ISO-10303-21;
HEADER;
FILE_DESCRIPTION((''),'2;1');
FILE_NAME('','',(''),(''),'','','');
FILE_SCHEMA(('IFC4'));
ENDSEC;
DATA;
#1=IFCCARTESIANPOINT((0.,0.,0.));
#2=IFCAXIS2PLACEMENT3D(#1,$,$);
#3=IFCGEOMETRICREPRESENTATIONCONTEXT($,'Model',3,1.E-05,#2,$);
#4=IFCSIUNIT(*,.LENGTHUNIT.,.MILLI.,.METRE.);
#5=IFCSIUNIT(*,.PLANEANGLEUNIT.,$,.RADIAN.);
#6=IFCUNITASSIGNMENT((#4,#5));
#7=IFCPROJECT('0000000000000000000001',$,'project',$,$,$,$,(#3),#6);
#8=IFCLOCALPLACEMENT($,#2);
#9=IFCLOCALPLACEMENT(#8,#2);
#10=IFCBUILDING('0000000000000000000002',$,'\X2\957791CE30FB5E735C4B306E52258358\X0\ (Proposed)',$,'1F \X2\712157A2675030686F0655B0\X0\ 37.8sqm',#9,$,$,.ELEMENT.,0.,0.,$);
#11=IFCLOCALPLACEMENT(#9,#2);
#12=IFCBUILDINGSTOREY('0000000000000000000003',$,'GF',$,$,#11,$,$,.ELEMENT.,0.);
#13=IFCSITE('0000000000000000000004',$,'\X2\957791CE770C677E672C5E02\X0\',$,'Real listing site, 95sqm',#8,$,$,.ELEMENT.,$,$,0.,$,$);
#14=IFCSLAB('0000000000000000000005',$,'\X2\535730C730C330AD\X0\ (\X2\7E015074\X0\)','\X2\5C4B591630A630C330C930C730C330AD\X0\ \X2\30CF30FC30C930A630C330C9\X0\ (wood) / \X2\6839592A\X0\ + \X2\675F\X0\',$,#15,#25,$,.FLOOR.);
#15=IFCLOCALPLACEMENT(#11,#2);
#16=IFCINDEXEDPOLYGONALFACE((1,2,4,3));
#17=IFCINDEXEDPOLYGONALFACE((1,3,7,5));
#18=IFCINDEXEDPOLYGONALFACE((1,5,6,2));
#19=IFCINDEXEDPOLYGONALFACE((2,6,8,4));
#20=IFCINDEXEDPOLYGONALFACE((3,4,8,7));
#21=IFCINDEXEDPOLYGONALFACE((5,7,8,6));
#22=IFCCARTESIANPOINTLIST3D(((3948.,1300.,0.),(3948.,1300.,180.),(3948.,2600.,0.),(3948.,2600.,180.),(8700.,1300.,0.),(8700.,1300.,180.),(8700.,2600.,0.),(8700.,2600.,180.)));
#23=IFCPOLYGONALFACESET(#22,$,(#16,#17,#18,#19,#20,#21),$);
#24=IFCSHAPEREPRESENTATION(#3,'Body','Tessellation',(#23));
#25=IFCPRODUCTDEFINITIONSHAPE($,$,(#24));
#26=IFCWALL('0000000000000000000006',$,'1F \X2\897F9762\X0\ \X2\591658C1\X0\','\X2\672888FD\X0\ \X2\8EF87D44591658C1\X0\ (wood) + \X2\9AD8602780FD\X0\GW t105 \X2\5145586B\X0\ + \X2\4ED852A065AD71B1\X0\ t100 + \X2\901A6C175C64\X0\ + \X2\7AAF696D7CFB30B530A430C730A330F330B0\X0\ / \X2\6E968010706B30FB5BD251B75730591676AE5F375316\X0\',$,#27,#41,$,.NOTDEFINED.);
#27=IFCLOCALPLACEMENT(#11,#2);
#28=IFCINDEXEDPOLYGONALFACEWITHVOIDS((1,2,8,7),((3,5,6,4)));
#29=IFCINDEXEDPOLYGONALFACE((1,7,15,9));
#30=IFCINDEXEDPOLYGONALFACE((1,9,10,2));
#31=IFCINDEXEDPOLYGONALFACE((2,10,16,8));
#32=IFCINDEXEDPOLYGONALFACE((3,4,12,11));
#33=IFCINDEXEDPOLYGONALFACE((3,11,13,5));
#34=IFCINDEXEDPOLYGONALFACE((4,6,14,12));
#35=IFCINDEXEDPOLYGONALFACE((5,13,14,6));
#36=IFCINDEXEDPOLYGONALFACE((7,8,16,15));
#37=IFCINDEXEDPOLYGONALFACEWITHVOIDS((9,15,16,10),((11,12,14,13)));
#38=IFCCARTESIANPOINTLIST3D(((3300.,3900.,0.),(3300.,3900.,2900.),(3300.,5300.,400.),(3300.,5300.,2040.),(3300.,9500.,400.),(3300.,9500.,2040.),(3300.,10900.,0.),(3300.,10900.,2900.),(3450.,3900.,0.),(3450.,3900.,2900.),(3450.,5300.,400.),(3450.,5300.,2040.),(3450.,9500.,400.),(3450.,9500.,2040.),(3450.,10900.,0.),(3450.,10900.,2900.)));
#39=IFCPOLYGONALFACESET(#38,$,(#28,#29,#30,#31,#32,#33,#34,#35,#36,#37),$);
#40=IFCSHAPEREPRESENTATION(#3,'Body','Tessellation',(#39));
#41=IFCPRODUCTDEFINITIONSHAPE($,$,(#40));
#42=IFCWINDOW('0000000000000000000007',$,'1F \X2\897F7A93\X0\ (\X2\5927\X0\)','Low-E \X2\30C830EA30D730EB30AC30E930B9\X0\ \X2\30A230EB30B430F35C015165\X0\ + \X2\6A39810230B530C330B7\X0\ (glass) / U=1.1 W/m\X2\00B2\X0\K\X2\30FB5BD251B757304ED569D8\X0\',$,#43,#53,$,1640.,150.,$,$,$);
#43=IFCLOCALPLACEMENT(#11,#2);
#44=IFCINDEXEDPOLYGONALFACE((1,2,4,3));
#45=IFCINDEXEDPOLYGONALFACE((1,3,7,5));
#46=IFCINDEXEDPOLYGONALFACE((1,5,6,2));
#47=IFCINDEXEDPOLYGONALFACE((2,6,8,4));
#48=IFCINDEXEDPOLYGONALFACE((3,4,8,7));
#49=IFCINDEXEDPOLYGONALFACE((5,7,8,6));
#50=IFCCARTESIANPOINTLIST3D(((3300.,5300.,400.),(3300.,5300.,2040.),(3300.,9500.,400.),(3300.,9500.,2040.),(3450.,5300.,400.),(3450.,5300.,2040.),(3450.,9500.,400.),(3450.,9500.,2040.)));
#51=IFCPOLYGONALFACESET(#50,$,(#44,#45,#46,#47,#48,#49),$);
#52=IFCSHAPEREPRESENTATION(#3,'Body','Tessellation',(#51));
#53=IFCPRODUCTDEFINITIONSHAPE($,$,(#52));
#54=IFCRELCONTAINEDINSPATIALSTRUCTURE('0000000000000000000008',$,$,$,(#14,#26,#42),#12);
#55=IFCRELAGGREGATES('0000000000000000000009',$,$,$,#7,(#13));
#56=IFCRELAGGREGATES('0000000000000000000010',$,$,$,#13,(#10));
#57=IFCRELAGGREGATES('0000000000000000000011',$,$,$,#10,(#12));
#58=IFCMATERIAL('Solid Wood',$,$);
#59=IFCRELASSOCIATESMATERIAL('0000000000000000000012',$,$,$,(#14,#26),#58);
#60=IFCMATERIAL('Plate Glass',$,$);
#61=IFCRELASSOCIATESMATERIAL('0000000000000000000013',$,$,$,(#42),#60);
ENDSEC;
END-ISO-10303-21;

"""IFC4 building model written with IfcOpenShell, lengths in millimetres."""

from ifc_helpers import new_model, si_unit, frame, frame_2d, origin, place, context, project, spatial, rectangle, extrude, material, element, fill, save


model = new_model("IFC4")

# Units and contexts
model_context = context("Model", 3, precision=1e-05, world=origin())
ifc_project = project(units=[si_unit("LENGTHUNIT", "METRE", prefix="MILLI"), si_unit("PLANEANGLEUNIT", "RADIAN")], contexts=[model_context])

# Site, building, storey
site_placement = place(None, origin())
site = spatial("IfcSite", under=ifc_project, at=site_placement, Name="長野県松本市", ObjectType="Real listing site, 95sqm", CompositionType="ELEMENT", RefElevation=0.0)
building_placement = place(site_placement, origin())
building = spatial("IfcBuilding", under=site, at=building_placement, Name="長野・平屋の別荘 (Proposed)", ObjectType="1F 無垢材と漆喰 37.8sqm", CompositionType="ELEMENT", ElevationOfRefHeight=0.0, ElevationOfTerrain=0.0)
storey_placement = place(building_placement, origin())
storey = spatial("IfcBuildingStorey", under=building, at=storey_placement, Name="GF", CompositionType="ELEMENT", Elevation=0.0)

# Shared definitions
ifc_material_1 = material(Name="Solid Wood")

# Slab
slab_1_placement = place(storey_placement, frame((1974.0, 650.0, 0.0)))
element("IfcSlab", 1, at=slab_1_placement, inside=storey, material=ifc_material_1, Name="南デッキ (縁側)", Description="屋外ウッドデッキ ハードウッド (wood) / 根太 + 束", PredefinedType="FLOOR", context=model_context, shape_type="SweptSolid", body=[
    extrude(rectangle(XDim=4752.0, YDim=1300.0, at=frame_2d((2376.0, 650.0))), frame((1974.0, 650.0, 0.0)), (0.0, 0.0, 1.0), 180.0),
])

# Shared definitions
ifc_material_2 = material(Name="Plate Glass")

# Wall, opening, window
wall_1_placement = place(storey_placement, frame((1650.0, 1950.0, 0.0)))
wall_1 = element("IfcWall", 2, at=wall_1_placement, inside=storey, material=ifc_material_1, Name="1F 西面 外壁", Description="木製 軸組外壁 (wood) + 高性能GW t105 充填 + 付加断熱 t100 + 通気層 + 窯業系サイディング / 準耐火・寒冷地外皮強化", PredefinedType="NOTDEFINED", context=model_context, shape_type="SweptSolid", body=[
    extrude(rectangle(XDim=150.0, YDim=7000.0, at=frame_2d((75.0, 3500.0))), frame((1650.0, 1950.0, 0.0)), (0.0, 0.0, 1.0), 2900.0),
])
opening_1_placement = place(storey_placement, frame((1650.0, 2650.0, 200.0)))
opening_1 = element("IfcOpeningElement", 3, at=opening_1_placement, cuts=wall_1, PredefinedType="NOTDEFINED", context=model_context, shape_type="SweptSolid", body=[
    extrude(rectangle(XDim=150.0, YDim=4200.0, at=frame_2d((75.0, 2100.0))), frame((1650.0, 2650.0, 200.0)), (0.0, 0.0, 1.0), 1640.0),
])
window_1_placement = place(storey_placement, frame((1650.0, 2650.0, 200.0)))
window_1 = element("IfcWindow", 4, at=window_1_placement, inside=storey, material=ifc_material_2, Name="1F 西窓 (大)", Description="Low-E トリプルガラス アルゴン封入 + 樹脂サッシ (glass) / U=1.1 W/m²K・寒冷地仕様", OverallHeight=1640.0, OverallWidth=150.0, context=model_context, shape_type="SweptSolid", body=[
    extrude(rectangle(XDim=150.0, YDim=4200.0, at=frame_2d((75.0, 2100.0))), frame((1650.0, 2650.0, 200.0)), (0.0, 0.0, 1.0), 1640.0),
])
fill(opening_1, window_1)

save(model, "model.ifc")
